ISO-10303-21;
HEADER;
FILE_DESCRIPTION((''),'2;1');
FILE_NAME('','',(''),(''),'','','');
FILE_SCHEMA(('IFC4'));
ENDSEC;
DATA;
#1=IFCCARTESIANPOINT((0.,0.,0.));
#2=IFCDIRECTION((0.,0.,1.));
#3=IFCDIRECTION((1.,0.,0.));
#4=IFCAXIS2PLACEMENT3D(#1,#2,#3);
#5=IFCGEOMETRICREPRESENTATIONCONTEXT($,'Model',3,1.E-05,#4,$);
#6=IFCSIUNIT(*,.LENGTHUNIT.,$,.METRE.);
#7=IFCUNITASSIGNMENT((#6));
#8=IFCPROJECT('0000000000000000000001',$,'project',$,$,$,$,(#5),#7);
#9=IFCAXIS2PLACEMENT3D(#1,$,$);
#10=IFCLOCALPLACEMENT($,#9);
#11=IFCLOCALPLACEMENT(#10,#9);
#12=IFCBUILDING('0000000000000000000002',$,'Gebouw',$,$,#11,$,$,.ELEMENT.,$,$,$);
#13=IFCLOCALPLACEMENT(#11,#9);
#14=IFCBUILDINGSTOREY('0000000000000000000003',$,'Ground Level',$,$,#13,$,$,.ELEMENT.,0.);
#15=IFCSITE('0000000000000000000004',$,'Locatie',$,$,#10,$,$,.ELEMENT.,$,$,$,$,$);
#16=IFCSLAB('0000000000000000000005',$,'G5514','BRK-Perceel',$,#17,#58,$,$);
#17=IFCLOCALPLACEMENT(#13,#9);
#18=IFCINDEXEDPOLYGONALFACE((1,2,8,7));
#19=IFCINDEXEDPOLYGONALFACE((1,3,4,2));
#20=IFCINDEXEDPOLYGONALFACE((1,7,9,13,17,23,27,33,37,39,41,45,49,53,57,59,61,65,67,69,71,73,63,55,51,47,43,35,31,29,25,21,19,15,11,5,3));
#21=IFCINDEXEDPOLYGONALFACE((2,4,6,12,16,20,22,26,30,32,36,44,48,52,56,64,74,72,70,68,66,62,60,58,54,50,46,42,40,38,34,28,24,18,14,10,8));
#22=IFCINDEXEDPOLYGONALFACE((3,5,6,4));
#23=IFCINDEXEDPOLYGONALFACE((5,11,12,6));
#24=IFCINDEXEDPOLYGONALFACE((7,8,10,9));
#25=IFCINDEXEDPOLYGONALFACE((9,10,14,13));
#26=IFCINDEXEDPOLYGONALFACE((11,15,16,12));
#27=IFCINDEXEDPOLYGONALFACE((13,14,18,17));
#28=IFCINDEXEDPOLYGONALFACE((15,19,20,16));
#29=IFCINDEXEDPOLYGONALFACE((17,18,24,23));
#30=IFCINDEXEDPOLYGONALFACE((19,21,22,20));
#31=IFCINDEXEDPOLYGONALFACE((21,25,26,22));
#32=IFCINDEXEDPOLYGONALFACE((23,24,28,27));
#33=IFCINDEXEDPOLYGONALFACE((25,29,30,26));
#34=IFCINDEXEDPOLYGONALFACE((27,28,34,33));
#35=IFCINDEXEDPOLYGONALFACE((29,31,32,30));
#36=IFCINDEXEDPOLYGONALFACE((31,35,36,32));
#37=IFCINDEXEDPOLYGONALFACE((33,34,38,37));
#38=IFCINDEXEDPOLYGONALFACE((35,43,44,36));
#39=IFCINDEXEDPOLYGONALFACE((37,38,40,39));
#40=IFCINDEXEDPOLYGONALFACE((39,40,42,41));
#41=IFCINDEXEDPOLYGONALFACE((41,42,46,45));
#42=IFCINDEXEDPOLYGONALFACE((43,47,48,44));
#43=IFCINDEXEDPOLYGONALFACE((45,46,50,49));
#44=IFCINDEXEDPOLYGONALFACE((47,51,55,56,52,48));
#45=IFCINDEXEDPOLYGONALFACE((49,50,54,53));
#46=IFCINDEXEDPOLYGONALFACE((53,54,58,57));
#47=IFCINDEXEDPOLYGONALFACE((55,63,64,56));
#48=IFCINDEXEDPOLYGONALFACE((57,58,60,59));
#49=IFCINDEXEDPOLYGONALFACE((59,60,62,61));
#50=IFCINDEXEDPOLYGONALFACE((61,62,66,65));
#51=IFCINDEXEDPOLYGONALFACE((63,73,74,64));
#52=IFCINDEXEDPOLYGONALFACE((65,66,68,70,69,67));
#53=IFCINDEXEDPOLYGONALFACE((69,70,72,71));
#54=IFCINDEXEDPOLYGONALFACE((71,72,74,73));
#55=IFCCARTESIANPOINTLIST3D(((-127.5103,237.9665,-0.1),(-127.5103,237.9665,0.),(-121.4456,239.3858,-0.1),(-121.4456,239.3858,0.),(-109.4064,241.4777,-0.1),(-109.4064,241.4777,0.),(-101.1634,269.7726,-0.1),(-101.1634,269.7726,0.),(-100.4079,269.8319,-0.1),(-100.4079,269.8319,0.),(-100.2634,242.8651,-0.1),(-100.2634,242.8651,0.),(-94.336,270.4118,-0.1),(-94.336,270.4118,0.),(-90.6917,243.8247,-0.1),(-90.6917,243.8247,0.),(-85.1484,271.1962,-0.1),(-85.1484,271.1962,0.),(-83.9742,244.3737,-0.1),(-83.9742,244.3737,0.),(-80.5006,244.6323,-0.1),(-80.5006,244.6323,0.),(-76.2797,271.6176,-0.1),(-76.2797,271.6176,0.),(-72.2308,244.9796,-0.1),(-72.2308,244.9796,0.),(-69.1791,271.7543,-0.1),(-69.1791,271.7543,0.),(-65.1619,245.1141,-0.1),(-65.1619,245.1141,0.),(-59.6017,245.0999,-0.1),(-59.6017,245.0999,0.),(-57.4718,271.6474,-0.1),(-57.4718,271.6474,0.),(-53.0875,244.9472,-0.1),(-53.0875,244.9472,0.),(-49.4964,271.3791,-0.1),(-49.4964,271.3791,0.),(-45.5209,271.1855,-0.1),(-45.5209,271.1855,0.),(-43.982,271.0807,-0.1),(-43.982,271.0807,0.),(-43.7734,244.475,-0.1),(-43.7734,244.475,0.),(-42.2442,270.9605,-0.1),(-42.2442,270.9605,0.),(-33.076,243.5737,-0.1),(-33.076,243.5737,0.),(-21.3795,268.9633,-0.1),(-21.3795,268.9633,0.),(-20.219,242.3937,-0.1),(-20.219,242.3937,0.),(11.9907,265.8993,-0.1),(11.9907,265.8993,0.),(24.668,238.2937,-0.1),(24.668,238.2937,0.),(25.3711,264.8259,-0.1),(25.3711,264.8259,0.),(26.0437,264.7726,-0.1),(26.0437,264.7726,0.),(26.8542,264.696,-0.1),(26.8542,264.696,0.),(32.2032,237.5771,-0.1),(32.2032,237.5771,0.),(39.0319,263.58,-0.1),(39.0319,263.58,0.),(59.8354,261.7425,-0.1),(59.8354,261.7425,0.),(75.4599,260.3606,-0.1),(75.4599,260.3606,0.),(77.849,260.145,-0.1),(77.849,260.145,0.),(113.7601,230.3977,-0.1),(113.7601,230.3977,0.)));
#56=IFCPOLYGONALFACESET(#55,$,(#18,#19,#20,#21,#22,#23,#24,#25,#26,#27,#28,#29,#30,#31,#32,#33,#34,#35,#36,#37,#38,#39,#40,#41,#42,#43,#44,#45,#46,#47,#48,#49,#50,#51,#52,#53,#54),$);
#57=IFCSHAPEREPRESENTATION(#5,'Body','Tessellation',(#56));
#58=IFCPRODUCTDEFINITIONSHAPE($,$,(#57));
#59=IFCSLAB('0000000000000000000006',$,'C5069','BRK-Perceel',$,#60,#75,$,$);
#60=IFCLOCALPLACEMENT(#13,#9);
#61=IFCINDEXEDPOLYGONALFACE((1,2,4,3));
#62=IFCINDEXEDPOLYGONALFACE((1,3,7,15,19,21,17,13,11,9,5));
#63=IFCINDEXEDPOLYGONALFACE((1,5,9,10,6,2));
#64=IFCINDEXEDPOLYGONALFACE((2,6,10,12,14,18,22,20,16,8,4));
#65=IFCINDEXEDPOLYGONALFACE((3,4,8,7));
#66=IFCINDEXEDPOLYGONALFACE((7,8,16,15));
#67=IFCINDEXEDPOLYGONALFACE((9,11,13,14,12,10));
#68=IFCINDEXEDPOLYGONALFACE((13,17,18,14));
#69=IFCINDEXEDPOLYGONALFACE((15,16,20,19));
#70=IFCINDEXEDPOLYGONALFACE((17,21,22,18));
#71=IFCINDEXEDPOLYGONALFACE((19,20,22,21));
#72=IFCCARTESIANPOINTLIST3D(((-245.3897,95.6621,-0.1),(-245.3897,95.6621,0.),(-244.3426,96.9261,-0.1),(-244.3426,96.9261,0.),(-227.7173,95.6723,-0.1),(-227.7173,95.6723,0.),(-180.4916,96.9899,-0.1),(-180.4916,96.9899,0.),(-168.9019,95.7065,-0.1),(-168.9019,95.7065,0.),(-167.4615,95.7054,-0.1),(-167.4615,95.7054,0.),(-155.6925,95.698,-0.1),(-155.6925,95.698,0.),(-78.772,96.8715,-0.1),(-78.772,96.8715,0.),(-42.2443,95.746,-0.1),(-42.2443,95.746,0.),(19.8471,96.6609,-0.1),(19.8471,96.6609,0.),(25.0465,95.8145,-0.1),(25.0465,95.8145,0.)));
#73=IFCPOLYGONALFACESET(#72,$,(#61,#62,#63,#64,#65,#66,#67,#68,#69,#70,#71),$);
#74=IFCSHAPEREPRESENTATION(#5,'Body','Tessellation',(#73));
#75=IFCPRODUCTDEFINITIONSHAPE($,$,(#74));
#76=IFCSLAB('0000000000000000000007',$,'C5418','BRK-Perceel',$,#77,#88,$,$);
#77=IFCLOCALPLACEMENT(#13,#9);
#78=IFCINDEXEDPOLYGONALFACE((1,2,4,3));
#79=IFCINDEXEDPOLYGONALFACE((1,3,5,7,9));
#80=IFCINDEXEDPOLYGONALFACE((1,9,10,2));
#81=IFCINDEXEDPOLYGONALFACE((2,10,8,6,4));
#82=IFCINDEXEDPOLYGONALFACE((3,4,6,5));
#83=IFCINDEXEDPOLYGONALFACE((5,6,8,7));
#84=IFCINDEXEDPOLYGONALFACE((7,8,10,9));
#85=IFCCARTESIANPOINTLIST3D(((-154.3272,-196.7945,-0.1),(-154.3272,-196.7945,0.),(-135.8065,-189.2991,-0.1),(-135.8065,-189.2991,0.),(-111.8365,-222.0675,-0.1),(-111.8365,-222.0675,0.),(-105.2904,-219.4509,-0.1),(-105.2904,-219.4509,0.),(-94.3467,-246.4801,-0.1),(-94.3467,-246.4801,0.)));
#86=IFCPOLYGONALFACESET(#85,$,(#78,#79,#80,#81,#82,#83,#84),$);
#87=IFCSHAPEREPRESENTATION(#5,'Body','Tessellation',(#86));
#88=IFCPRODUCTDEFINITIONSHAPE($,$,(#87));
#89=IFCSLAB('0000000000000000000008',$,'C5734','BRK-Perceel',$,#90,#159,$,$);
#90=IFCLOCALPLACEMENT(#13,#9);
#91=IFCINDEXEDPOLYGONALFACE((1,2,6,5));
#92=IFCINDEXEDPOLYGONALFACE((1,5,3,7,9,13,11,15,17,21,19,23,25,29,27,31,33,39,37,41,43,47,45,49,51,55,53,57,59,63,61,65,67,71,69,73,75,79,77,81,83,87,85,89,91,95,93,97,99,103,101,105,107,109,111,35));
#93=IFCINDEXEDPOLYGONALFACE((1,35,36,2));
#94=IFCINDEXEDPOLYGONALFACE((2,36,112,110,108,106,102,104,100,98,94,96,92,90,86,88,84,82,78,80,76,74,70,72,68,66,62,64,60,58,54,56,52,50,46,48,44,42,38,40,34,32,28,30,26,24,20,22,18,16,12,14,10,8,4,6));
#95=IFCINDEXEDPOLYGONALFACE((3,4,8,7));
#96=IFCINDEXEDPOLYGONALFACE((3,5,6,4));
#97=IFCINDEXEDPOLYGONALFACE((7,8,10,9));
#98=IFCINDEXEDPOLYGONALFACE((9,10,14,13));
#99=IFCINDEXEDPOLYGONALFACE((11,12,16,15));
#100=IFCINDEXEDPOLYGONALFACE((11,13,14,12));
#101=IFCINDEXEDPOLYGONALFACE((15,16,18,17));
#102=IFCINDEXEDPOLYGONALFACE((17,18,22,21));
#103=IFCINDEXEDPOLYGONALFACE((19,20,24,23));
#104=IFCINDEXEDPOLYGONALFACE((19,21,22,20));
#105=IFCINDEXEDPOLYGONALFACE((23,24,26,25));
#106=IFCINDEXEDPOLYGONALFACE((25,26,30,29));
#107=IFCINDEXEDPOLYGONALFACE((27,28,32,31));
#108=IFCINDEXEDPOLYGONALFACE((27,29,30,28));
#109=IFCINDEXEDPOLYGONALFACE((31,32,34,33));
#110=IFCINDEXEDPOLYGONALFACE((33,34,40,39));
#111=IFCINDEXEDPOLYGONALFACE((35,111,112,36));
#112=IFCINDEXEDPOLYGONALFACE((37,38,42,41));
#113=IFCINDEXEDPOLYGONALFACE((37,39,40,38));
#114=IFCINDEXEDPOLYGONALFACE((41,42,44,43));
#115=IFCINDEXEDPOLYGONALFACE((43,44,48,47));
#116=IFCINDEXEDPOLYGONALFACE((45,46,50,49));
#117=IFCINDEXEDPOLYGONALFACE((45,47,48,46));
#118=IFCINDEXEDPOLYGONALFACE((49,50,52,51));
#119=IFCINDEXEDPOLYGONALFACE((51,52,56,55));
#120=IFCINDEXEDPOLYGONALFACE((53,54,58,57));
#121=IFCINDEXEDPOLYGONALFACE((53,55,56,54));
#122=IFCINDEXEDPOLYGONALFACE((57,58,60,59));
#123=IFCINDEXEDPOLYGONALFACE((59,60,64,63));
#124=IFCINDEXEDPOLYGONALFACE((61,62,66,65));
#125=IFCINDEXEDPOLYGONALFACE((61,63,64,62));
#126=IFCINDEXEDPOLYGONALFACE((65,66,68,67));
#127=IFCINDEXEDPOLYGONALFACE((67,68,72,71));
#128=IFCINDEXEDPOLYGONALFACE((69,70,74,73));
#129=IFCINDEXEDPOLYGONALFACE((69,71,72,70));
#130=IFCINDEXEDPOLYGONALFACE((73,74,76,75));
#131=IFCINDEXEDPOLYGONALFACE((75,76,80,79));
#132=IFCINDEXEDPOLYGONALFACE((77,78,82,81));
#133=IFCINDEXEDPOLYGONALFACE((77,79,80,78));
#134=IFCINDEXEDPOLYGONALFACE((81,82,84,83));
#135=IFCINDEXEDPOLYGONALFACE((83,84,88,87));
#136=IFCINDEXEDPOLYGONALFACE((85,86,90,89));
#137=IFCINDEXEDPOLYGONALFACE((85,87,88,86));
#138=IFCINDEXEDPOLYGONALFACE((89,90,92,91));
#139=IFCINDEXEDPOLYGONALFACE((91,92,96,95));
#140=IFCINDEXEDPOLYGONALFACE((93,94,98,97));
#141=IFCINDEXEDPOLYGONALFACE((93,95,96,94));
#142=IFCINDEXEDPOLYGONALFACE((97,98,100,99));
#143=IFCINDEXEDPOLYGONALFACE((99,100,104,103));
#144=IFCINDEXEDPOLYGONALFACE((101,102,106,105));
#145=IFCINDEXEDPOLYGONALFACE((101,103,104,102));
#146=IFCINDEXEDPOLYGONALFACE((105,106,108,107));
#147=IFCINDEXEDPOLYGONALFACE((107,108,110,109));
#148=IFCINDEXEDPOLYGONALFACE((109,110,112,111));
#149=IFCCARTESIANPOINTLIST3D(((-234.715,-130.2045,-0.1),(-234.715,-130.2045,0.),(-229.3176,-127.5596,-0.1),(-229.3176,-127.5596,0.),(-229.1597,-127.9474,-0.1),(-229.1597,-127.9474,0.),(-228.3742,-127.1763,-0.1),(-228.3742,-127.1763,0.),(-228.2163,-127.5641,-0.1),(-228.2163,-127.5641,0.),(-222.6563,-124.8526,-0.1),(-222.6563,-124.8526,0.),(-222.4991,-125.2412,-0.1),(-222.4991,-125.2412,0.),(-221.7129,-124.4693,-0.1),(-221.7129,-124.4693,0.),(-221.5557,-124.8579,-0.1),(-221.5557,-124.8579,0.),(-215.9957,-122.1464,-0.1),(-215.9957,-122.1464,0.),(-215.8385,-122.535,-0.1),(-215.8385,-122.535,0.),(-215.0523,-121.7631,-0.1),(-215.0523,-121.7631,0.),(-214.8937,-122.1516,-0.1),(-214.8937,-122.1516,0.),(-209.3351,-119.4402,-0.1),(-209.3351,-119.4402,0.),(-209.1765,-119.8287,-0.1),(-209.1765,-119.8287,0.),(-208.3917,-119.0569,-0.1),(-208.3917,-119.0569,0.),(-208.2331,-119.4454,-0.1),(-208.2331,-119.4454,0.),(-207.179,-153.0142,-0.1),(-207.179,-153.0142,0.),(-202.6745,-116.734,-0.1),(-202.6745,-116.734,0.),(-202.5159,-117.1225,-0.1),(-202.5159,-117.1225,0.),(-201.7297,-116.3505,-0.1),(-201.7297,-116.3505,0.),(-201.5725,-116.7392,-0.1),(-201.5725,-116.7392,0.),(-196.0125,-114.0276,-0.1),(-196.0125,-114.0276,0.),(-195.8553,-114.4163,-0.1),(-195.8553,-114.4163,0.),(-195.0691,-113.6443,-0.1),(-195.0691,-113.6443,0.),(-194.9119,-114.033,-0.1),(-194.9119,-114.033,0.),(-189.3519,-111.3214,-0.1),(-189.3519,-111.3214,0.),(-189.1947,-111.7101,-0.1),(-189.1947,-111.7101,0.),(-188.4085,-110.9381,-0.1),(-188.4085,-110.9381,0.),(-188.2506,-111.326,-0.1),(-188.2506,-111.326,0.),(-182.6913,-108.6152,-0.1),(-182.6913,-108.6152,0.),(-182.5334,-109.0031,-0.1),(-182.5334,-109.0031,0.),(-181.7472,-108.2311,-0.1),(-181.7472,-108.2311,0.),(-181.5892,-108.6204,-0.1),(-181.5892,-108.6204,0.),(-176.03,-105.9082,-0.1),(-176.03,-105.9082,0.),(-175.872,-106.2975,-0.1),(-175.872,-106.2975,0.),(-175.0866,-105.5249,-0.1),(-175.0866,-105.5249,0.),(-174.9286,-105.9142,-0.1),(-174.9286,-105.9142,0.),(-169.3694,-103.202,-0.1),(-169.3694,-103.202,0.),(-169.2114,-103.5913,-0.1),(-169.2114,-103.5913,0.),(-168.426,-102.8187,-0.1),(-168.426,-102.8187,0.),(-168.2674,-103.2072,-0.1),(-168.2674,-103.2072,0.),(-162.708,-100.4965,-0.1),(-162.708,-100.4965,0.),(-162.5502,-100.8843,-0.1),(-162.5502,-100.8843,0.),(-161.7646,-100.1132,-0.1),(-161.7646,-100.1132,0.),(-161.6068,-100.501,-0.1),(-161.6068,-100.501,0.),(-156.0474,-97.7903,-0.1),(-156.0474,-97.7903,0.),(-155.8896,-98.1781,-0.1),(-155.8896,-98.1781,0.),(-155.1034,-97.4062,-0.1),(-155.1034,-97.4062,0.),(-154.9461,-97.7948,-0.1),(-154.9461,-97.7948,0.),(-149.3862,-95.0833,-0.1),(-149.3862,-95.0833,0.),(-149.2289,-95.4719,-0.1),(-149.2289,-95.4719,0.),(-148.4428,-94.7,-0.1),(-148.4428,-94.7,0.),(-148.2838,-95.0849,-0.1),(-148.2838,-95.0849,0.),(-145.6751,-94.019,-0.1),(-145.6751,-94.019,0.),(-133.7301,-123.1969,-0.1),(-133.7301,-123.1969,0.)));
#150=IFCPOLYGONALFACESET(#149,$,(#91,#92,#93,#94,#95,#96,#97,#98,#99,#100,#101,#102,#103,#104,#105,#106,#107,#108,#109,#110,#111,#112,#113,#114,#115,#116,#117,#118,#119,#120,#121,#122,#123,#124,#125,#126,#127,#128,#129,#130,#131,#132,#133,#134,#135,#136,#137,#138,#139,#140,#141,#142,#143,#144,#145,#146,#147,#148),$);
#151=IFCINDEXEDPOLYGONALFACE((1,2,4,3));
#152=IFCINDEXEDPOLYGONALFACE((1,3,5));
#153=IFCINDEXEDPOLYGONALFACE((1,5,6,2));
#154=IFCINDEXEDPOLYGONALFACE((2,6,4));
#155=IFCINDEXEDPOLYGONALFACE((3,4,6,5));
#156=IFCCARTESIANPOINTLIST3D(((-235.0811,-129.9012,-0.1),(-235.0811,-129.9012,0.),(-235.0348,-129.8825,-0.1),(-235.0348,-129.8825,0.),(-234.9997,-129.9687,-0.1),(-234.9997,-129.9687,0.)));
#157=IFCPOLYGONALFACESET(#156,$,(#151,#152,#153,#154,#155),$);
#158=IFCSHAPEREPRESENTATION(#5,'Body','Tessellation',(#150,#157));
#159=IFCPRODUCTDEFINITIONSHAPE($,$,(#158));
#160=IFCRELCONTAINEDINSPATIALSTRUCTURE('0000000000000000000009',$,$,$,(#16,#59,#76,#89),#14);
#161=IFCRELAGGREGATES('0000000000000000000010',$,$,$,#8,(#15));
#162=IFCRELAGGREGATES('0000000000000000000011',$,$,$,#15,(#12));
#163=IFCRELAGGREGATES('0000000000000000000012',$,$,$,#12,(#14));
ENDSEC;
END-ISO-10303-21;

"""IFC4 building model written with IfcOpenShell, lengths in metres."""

from ifc_helpers import new_model, si_unit, frame, origin, origin_with_axes, place, context, project, spatial, polyline, outline, extrude, element, save


model = new_model("IFC4")

# Units and contexts
model_context = context("Model", 3, precision=1e-05, world=origin_with_axes())
ifc_project = project(units=[si_unit("LENGTHUNIT", "METRE")], contexts=[model_context])

# Site, building, storey
site_placement = place(None, origin())
site = spatial("IfcSite", under=ifc_project, at=site_placement, Name="Locatie", CompositionType="ELEMENT")
building_placement = place(site_placement, origin())
building = spatial("IfcBuilding", under=site, at=building_placement, Name="Gebouw", CompositionType="ELEMENT")
storey_placement = place(building_placement, origin())
storey = spatial("IfcBuildingStorey", under=building, at=storey_placement, Name="Ground Level", CompositionType="ELEMENT", Elevation=0.0)

# Slabs
slab_1_placement = place(storey_placement, origin())
element("IfcSlab", 1, at=slab_1_placement, inside=storey, Name="G5514", Description="BRK-Perceel", context=model_context, shape_type="SweptSolid", body=[
    extrude(outline(polyline([(-100.4079, 269.8319), (-94.336, 270.4118), (-85.1484, 271.1962), (-76.2797, 271.6176), (-69.1791, 271.7543), (-57.4718, 271.6474), (-49.4964, 271.3791), (-45.5209, 271.1855), (-43.982, 271.0807), (-42.2442, 270.9605), (-21.3795, 268.9633), (11.9907, 265.8993), (25.3711, 264.8259), (26.0437, 264.7726), (26.8542, 264.696), (39.0319, 263.58), (59.8354, 261.7425), (75.4599, 260.3606), (77.849, 260.145), (113.7601, 230.3977), (32.2032, 237.5771), (24.668, 238.2937), (-20.219, 242.3937), (-33.076, 243.5737), (-43.7734, 244.475), (-53.0875, 244.9472), (-59.6017, 245.0999), (-65.1619, 245.1141), (-72.2308, 244.9796), (-80.5006, 244.6323), (-83.9742, 244.3737), (-90.6917, 243.8247), (-100.2634, 242.8651), (-109.4064, 241.4777), (-121.4456, 239.3858), (-127.5103, 237.9665), (-101.1634, 269.7726), (-100.4079, 269.8319)])), frame((0.0, 0.0, -0.1), z_axis=(0.0, 0.0, 1.0), x_axis=(1.0, 0.0, 0.0)), (0.0, 0.0, 1.0), 0.1),
])
slab_2_placement = place(storey_placement, origin())
element("IfcSlab", 2, at=slab_2_placement, inside=storey, Name="C5069", Description="BRK-Perceel", context=model_context, shape_type="SweptSolid", body=[
    extrude(outline(polyline([(-180.4916, 96.9899), (-78.772, 96.8715), (19.8471, 96.6609), (25.0465, 95.8145), (-42.2443, 95.746), (-155.6925, 95.698), (-167.4615, 95.7054), (-168.9019, 95.7065), (-227.7173, 95.6723), (-245.3897, 95.6621), (-244.3426, 96.9261), (-180.4916, 96.9899)])), frame((0.0, 0.0, -0.1), z_axis=(0.0, 0.0, 1.0), x_axis=(1.0, 0.0, 0.0)), (0.0, 0.0, 1.0), 0.1),
])
slab_3_placement = place(storey_placement, origin())
element("IfcSlab", 3, at=slab_3_placement, inside=storey, Name="C5418", Description="BRK-Perceel", context=model_context, shape_type="SweptSolid", body=[
    extrude(outline(polyline([(-135.8065, -189.2991), (-111.8365, -222.0675), (-105.2904, -219.4509), (-94.3467, -246.4801), (-154.3272, -196.7945), (-135.8065, -189.2991)])), frame((0.0, 0.0, -0.1), z_axis=(0.0, 0.0, 1.0), x_axis=(1.0, 0.0, 0.0)), (0.0, 0.0, 1.0), 0.1),
])
slab_4_placement = place(storey_placement, origin())
element("IfcSlab", 4, at=slab_4_placement, inside=storey, Name="C5734", Description="BRK-Perceel", context=model_context, shape_type="SweptSolid", body=[
    extrude(outline(polyline([(-229.1597, -127.9474), (-229.3176, -127.5596), (-228.3742, -127.1763), (-228.2163, -127.5641), (-222.4991, -125.2412), (-222.6563, -124.8526), (-221.7129, -124.4693), (-221.5557, -124.8579), (-215.8385, -122.535), (-215.9957, -122.1464), (-215.0523, -121.7631), (-214.8937, -122.1516), (-209.1765, -119.8287), (-209.3351, -119.4402), (-208.3917, -119.0569), (-208.2331, -119.4454), (-202.5159, -117.1225), (-202.6745, -116.734), (-201.7297, -116.3505), (-201.5725, -116.7392), (-195.8553, -114.4163), (-196.0125, -114.0276), (-195.0691, -113.6443), (-194.9119, -114.033), (-189.1947, -111.7101), (-189.3519, -111.3214), (-188.4085, -110.9381), (-188.2506, -111.326), (-182.5334, -109.0031), (-182.6913, -108.6152), (-181.7472, -108.2311), (-181.5892, -108.6204), (-175.872, -106.2975), (-176.03, -105.9082), (-175.0866, -105.5249), (-174.9286, -105.9142), (-169.2114, -103.5913), (-169.3694, -103.202), (-168.426, -102.8187), (-168.2674, -103.2072), (-162.5502, -100.8843), (-162.708, -100.4965), (-161.7646, -100.1132), (-161.6068, -100.501), (-155.8896, -98.1781), (-156.0474, -97.7903), (-155.1034, -97.4062), (-154.9461, -97.7948), (-149.2289, -95.4719), (-149.3862, -95.0833), (-148.4428, -94.7), (-148.2838, -95.0849), (-145.6751, -94.019), (-133.7301, -123.1969), (-207.179, -153.0142), (-234.715, -130.2045), (-229.1597, -127.9474)])), frame((0.0, 0.0, -0.1), z_axis=(0.0, 0.0, 1.0), x_axis=(1.0, 0.0, 0.0)), (0.0, 0.0, 1.0), 0.1),
    extrude(outline(polyline([(-235.0348, -129.8825), (-234.9997, -129.9687), (-235.0811, -129.9012), (-235.0348, -129.8825)])), frame((0.0, 0.0, -0.1), z_axis=(0.0, 0.0, 1.0), x_axis=(1.0, 0.0, 0.0)), (0.0, 0.0, 1.0), 0.1),
])

save(model, "model.ifc")
